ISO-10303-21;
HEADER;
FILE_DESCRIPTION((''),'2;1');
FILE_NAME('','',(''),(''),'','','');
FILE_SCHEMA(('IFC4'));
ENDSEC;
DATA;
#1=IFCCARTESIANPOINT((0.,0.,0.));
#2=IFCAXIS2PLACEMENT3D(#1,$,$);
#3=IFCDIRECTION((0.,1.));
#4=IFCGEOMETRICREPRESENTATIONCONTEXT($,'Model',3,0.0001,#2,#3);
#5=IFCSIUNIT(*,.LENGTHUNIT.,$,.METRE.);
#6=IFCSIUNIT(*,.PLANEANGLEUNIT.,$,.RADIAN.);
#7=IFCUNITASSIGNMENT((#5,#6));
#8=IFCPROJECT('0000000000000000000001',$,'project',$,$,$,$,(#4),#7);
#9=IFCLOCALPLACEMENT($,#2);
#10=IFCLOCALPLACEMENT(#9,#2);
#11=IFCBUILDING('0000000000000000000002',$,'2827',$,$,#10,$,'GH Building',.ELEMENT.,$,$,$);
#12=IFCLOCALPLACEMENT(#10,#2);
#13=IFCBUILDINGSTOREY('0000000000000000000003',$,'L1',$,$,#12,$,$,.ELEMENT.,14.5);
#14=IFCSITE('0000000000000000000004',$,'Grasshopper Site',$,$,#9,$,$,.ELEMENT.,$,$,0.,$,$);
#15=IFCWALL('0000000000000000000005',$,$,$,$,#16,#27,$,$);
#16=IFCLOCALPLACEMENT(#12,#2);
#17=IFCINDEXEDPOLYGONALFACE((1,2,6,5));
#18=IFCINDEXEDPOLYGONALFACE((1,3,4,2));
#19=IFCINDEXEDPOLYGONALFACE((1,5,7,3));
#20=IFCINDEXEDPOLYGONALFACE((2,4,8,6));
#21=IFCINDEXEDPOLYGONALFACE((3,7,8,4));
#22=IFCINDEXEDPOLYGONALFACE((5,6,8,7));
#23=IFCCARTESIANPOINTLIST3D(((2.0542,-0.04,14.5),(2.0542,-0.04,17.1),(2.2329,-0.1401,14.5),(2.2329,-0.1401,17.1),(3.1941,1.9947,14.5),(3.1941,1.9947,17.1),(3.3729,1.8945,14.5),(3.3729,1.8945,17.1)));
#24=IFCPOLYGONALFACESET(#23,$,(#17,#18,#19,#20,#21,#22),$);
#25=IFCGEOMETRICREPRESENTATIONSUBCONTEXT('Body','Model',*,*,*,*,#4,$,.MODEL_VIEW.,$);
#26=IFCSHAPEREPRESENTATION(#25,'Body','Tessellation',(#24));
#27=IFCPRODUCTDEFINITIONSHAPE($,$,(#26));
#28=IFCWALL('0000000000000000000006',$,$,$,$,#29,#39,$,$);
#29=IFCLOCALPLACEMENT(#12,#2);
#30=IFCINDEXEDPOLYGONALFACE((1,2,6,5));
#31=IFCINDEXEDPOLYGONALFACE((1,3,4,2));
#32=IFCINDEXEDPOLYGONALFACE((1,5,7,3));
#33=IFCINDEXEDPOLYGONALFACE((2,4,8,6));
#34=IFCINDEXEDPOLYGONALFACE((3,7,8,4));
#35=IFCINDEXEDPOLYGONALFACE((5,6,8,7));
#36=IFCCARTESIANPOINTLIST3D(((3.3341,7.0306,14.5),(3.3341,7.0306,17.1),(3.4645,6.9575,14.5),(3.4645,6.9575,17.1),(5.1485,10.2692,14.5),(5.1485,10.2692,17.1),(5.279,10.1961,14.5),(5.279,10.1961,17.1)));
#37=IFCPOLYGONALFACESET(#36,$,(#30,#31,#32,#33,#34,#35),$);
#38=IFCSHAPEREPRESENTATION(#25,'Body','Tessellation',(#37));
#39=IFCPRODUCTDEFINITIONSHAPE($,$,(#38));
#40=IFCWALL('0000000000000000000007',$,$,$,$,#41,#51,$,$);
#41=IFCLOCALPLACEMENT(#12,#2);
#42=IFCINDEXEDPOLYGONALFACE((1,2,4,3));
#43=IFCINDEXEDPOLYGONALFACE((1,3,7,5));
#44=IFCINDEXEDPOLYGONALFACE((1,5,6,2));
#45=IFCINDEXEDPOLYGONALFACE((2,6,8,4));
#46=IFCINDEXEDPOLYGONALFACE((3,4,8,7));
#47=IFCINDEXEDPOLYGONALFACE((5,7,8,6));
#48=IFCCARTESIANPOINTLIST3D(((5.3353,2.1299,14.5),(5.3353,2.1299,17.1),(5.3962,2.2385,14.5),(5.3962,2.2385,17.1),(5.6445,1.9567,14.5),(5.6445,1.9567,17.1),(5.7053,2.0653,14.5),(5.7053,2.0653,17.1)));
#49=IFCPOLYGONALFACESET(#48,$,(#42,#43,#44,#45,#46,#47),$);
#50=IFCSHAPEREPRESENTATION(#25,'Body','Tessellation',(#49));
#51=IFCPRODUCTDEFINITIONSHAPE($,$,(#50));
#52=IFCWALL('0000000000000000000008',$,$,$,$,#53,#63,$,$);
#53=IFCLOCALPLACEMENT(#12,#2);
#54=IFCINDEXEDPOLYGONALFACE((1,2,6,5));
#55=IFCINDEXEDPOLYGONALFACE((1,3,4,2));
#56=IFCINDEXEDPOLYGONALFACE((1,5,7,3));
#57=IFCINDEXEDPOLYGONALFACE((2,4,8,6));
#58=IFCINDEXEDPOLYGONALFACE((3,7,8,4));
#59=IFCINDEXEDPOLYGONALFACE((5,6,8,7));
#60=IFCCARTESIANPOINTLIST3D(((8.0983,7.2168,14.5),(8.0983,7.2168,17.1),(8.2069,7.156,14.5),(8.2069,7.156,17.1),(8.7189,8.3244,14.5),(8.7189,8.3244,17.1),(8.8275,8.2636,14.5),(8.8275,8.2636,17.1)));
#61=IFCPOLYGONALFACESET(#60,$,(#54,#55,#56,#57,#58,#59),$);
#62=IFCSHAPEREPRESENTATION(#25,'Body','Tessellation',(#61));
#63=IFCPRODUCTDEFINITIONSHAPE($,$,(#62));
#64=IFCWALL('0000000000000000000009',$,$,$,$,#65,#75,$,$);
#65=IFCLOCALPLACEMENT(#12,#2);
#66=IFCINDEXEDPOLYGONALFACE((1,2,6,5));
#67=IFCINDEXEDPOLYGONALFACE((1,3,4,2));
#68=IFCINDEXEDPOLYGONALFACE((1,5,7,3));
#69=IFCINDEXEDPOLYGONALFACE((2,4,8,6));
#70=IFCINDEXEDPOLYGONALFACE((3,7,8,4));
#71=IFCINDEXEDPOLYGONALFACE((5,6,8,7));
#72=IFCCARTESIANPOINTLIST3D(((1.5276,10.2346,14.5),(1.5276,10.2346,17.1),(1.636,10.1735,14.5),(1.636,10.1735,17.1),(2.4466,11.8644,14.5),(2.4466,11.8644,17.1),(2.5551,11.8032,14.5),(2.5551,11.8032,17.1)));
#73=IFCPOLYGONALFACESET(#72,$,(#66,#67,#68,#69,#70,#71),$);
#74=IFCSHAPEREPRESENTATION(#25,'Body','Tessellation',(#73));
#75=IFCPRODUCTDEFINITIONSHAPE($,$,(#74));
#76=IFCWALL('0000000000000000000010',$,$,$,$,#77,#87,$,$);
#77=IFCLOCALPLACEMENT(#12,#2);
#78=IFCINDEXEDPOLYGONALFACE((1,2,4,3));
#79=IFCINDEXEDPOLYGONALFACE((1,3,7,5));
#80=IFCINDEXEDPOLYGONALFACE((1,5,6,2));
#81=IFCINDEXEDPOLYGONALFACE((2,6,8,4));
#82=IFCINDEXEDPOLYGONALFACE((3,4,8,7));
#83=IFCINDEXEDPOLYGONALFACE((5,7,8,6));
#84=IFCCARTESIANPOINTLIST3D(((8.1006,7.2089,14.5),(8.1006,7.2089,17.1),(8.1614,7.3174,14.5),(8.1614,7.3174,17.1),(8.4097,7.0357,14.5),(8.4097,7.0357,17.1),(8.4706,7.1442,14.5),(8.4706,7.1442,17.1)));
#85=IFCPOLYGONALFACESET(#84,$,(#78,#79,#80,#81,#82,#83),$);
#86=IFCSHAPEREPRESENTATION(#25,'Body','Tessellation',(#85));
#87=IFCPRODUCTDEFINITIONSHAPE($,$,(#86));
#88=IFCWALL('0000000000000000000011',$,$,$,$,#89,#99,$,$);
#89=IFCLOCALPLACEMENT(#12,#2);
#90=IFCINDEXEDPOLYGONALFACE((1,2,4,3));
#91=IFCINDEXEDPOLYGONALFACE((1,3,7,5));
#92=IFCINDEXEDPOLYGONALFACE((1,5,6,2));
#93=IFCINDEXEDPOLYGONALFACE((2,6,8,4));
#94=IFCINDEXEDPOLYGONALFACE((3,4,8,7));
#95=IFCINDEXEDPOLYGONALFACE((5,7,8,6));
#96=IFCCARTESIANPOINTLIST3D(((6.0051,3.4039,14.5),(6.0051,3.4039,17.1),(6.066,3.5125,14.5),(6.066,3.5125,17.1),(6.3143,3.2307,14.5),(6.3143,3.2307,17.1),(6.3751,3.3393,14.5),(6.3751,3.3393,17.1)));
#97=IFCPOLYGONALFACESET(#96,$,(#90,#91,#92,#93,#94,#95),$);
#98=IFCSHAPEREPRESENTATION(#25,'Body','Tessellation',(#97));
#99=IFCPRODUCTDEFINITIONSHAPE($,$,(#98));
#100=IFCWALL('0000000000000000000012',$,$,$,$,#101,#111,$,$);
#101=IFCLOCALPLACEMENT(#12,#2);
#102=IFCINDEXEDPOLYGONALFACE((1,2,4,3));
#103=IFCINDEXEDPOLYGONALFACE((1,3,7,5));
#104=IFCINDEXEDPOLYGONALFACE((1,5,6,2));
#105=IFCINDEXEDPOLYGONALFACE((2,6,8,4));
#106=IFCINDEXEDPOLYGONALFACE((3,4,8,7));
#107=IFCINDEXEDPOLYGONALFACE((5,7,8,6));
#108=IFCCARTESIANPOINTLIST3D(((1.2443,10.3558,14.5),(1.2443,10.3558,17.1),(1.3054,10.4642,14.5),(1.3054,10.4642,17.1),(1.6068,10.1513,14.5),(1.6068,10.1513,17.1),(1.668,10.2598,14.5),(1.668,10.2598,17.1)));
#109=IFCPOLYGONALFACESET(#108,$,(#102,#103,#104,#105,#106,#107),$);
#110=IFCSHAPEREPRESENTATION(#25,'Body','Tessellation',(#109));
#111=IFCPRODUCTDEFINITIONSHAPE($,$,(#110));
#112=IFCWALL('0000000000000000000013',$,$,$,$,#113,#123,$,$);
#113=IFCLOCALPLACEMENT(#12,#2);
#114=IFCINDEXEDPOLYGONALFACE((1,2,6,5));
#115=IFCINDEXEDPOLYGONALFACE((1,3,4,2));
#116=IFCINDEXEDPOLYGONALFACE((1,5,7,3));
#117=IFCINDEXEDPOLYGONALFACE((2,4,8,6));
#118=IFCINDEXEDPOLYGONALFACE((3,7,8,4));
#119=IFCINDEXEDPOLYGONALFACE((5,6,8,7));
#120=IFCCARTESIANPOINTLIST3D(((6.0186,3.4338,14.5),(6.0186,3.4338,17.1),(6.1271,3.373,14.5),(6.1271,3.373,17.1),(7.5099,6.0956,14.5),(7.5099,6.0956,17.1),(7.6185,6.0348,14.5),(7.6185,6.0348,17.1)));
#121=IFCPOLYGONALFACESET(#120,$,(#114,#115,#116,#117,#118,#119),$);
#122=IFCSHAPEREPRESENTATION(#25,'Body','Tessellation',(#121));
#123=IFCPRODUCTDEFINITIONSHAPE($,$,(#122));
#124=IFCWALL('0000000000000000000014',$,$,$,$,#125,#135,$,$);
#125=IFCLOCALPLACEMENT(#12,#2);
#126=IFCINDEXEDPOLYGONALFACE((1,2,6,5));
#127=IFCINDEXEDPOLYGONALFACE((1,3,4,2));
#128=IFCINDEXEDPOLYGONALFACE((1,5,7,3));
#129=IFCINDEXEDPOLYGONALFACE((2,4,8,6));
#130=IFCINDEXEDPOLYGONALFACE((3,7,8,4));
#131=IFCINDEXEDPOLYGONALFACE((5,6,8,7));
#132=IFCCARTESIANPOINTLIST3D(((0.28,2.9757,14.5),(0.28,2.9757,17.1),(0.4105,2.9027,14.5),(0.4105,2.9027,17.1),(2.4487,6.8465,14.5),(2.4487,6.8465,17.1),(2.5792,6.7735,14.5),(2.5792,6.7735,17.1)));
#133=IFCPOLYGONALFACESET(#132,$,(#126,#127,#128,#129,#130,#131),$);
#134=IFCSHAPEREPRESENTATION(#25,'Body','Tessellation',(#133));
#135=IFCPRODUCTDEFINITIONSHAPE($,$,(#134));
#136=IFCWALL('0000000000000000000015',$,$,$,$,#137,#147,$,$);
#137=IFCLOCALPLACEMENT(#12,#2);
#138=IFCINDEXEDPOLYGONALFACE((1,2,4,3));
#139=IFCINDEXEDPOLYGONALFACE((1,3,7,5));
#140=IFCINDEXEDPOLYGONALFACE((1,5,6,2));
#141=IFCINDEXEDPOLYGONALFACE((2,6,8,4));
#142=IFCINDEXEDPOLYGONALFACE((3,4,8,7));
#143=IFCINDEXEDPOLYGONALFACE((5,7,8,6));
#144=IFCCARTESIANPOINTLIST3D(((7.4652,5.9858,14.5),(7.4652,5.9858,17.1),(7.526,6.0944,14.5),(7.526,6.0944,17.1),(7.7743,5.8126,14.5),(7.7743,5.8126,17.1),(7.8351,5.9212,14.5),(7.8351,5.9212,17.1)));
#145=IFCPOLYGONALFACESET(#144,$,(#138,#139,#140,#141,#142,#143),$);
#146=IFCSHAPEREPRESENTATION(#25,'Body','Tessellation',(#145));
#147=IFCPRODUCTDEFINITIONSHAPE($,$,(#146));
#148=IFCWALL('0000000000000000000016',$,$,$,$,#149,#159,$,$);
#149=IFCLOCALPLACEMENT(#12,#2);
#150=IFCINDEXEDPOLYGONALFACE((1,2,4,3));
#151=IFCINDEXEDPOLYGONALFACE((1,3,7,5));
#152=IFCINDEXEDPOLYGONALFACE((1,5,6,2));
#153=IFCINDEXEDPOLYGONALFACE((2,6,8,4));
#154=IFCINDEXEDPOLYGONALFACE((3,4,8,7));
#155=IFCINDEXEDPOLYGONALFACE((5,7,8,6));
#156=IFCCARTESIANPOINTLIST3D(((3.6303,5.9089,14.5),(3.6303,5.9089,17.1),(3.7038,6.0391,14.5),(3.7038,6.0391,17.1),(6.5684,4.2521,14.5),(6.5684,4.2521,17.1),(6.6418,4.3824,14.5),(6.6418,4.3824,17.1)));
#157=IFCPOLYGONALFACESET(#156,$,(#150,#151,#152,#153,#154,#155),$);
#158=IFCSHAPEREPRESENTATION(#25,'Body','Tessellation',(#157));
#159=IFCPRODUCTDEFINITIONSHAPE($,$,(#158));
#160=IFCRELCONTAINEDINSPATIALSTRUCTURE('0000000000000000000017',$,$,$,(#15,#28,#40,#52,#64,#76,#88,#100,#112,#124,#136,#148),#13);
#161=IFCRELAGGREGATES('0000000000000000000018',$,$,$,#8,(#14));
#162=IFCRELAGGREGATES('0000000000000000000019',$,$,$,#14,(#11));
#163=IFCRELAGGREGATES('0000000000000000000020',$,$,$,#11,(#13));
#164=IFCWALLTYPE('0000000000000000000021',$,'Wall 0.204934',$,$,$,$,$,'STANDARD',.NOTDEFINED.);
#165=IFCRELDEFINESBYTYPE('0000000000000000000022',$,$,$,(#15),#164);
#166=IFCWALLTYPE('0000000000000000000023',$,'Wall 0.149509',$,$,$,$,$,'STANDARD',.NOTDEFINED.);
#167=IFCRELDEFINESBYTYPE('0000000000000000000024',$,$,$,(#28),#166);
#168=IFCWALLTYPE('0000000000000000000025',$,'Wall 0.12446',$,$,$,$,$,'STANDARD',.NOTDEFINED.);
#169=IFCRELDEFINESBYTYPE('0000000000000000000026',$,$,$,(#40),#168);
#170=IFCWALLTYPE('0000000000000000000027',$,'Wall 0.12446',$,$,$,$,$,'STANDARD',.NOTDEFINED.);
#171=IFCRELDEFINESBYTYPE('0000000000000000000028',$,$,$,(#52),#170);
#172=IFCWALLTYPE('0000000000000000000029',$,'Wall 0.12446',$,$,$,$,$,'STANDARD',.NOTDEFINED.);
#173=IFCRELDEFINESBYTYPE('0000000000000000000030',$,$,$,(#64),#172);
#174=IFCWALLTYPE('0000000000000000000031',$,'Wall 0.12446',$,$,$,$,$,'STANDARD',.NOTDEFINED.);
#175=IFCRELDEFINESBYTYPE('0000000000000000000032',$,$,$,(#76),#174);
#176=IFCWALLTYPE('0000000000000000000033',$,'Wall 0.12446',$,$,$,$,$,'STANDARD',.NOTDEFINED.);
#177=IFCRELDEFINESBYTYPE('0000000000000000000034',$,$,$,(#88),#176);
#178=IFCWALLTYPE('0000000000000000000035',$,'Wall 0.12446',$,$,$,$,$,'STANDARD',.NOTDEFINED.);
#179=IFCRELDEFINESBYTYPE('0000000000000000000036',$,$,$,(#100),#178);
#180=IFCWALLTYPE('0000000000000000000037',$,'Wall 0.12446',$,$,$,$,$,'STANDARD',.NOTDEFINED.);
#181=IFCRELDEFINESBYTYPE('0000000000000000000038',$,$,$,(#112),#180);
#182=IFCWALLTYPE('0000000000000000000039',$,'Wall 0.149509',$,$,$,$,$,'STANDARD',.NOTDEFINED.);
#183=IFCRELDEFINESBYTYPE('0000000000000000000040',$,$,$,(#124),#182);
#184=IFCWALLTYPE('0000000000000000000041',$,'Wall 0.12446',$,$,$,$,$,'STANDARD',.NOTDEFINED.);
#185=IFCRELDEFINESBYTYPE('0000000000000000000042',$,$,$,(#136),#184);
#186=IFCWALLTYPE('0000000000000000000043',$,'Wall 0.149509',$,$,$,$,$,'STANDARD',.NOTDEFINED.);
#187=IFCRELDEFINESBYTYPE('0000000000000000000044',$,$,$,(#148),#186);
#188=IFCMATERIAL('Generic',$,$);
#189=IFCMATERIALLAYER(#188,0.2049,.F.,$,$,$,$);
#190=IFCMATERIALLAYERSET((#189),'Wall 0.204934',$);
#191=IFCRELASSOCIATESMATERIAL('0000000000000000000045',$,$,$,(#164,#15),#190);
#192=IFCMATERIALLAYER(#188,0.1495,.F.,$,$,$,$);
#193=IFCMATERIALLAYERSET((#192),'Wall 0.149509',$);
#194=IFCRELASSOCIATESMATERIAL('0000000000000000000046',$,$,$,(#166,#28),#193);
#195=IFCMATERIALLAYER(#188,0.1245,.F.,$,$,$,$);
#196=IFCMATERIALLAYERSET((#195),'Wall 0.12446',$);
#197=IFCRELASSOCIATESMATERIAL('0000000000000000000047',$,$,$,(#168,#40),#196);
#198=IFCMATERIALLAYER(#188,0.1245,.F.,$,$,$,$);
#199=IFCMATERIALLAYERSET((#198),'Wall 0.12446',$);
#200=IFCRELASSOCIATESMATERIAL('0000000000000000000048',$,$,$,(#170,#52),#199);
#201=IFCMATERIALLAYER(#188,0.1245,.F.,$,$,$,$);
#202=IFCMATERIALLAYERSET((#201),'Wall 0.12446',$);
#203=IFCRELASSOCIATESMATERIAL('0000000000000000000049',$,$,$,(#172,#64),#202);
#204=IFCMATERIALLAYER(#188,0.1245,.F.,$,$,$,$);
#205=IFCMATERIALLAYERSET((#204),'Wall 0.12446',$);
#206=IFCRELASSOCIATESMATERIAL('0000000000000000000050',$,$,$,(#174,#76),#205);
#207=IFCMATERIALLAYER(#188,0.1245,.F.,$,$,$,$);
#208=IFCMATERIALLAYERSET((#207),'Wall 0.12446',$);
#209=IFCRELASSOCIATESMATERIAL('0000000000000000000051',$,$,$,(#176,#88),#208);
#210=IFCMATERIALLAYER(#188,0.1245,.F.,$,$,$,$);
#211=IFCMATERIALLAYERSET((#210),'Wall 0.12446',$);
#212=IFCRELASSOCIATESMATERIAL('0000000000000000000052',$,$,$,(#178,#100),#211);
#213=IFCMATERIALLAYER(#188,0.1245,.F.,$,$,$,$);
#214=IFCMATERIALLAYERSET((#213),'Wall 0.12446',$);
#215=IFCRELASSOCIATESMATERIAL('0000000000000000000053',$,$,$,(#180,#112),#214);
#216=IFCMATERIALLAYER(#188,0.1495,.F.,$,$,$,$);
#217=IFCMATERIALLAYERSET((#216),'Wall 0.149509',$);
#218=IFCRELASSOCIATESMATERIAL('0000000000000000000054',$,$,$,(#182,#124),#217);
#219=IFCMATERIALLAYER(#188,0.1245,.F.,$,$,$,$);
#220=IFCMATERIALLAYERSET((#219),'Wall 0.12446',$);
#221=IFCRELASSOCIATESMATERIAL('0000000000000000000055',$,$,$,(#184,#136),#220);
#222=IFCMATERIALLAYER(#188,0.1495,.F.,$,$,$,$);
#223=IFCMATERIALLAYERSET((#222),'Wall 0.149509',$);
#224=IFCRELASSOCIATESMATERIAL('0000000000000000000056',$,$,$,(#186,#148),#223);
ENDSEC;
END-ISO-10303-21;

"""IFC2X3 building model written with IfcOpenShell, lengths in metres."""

from ifc_helpers import new_model, si_unit, direction, frame, frame_2d, origin, place, context, subcontext, project, spatial, rectangle, extrude, material, layer, layer_set, layer_usage, type_object, element, save


model = new_model("IFC2X3")

# Units and contexts
model_context = context("Model", 3, precision=0.0001, world=origin(), true_north=direction((0.0, 1.0)))
body_context = subcontext(model_context, "Body", "Model", "MODEL_VIEW")
ifc_project = project(units=[si_unit("LENGTHUNIT", "METRE"), si_unit("PLANEANGLEUNIT", "RADIAN")], contexts=[model_context])

# Site, building, storey
site_placement = place(None, origin())
site = spatial("IfcSite", under=ifc_project, at=site_placement, Name="Grasshopper Site", CompositionType="ELEMENT", RefElevation=0.0)
building_placement = place(site_placement, origin())
building = spatial("IfcBuilding", under=site, at=building_placement, Name="2827", LongName="GH Building", CompositionType="ELEMENT")
storey_placement = place(building_placement, origin())
storey = spatial("IfcBuildingStorey", under=building, at=storey_placement, Name="L1", CompositionType="ELEMENT", Elevation=14.5)

# Walls
ifc_material = material(Name="Generic")
ifc_layer_1 = layer(ifc_material, 0.2049, ventilated=False)
ifc_layer_set_1 = layer_set([ifc_layer_1], Name="Wall 0.204934")
ifc_layer_usage_1 = layer_usage(ifc_layer_set_1, "AXIS2", "NEGATIVE", 0.1025)
wall_type_1 = type_object("IfcWallType", Name="Wall 0.204934", ElementType="STANDARD", PredefinedType="NOTDEFINED", material=ifc_layer_set_1)
wall_1_placement = place(storey_placement, frame((3.2835, 1.9446, 14.5), z_axis=(0.0, 0.0, 1.0), x_axis=(-0.488782, -0.872406, 0.0)))
element("IfcWall", 1, at=wall_1_placement, inside=storey, type_object=wall_type_1, material=ifc_layer_usage_1, context=body_context, shape_type="SweptSolid", body=[
    extrude(rectangle(XDim=2.3322, YDim=0.2049, at=frame_2d((1.1661, 0.0))), origin(), (0.0, 0.0, 1.0), 2.6),
])
ifc_layer_2 = layer(ifc_material, 0.1495, ventilated=False)
ifc_layer_set_2 = layer_set([ifc_layer_2], Name="Wall 0.149509")
ifc_layer_usage_2 = layer_usage(ifc_layer_set_2, "AXIS2", "NEGATIVE", 0.0748)
wall_type_2 = type_object("IfcWallType", Name="Wall 0.149509", ElementType="STANDARD", PredefinedType="NOTDEFINED", material=ifc_layer_set_2)
wall_2_placement = place(storey_placement, frame((5.2138, 10.2327, 14.5), z_axis=(0.0, 0.0, 1.0), x_axis=(-0.488782, -0.872406, 0.0)))
element("IfcWall", 2, at=wall_2_placement, inside=storey, type_object=wall_type_2, material=ifc_layer_usage_2, context=body_context, shape_type="SweptSolid", body=[
    extrude(rectangle(XDim=3.7122, YDim=0.1495, at=frame_2d((1.8561, 0.0))), origin(), (0.0, 0.0, 1.0), 2.6),
])

# Walls
ifc_layer_3 = layer(ifc_material, 0.1245, ventilated=False)
ifc_layer_set_3 = layer_set([ifc_layer_3], Name="Wall 0.12446")
ifc_layer_usage_3 = layer_usage(ifc_layer_set_3, "AXIS2", "NEGATIVE", 0.0622)
wall_type_3 = type_object("IfcWallType", Name="Wall 0.12446", ElementType="STANDARD", PredefinedType="NOTDEFINED", material=ifc_layer_set_3)
wall_3_placement = place(storey_placement, frame((5.3657, 2.1842, 14.5), z_axis=(0.0, 0.0, 1.0), x_axis=(0.872406, -0.488782, 0.0)))
element("IfcWall", 3, at=wall_3_placement, inside=storey, type_object=wall_type_3, material=ifc_layer_usage_3, context=body_context, shape_type="SweptSolid", body=[
    extrude(rectangle(XDim=0.3544, YDim=0.1245, at=frame_2d((0.1772, 0.0))), origin(), (0.0, 0.0, 1.0), 2.6),
])
ifc_layer_4 = layer(ifc_material, 0.1245, ventilated=False)
ifc_layer_set_4 = layer_set([ifc_layer_4], Name="Wall 0.12446")
ifc_layer_usage_4 = layer_usage(ifc_layer_set_4, "AXIS2", "NEGATIVE", 0.0622)
wall_type_4 = type_object("IfcWallType", Name="Wall 0.12446", ElementType="STANDARD", PredefinedType="NOTDEFINED", material=ifc_layer_set_4)
wall_4_placement = place(storey_placement, frame((8.7732, 8.294, 14.5), z_axis=(0.0, 0.0, 1.0), x_axis=(-0.488782, -0.872406, 0.0)))
element("IfcWall", 4, at=wall_4_placement, inside=storey, type_object=wall_type_4, material=ifc_layer_usage_4, context=body_context, shape_type="SweptSolid", body=[
    extrude(rectangle(XDim=1.2696, YDim=0.1245, at=frame_2d((0.6348, 0.0))), origin(), (0.0, 0.0, 1.0), 2.6),
])
ifc_layer_5 = layer(ifc_material, 0.1245, ventilated=False)
ifc_layer_set_5 = layer_set([ifc_layer_5], Name="Wall 0.12446")
ifc_layer_usage_5 = layer_usage(ifc_layer_set_5, "AXIS2", "NEGATIVE", 0.0622)
wall_type_5 = type_object("IfcWallType", Name="Wall 0.12446", ElementType="STANDARD", PredefinedType="NOTDEFINED", material=ifc_layer_set_5)
wall_5_placement = place(storey_placement, frame((1.5818, 10.204, 14.5), z_axis=(0.0, 0.0, 1.0), x_axis=(0.491187, 0.871054, 0.0)))
element("IfcWall", 5, at=wall_5_placement, inside=storey, type_object=wall_type_5, material=ifc_layer_usage_5, context=body_context, shape_type="SweptSolid", body=[
    extrude(rectangle(XDim=1.871, YDim=0.1245, at=frame_2d((0.9355, 0.0))), origin(), (0.0, 0.0, 1.0), 2.6),
])
ifc_layer_6 = layer(ifc_material, 0.1245, ventilated=False)
ifc_layer_set_6 = layer_set([ifc_layer_6], Name="Wall 0.12446")
ifc_layer_usage_6 = layer_usage(ifc_layer_set_6, "AXIS2", "NEGATIVE", 0.0622)
wall_type_6 = type_object("IfcWallType", Name="Wall 0.12446", ElementType="STANDARD", PredefinedType="NOTDEFINED", material=ifc_layer_set_6)
wall_6_placement = place(storey_placement, frame((8.4402, 7.0899, 14.5), z_axis=(0.0, 0.0, 1.0), x_axis=(-0.872406, 0.488782, 0.0)))
element("IfcWall", 6, at=wall_6_placement, inside=storey, type_object=wall_type_6, material=ifc_layer_usage_6, context=body_context, shape_type="SweptSolid", body=[
    extrude(rectangle(XDim=0.3544, YDim=0.1245, at=frame_2d((0.1772, 0.0))), origin(), (0.0, 0.0, 1.0), 2.6),
])
ifc_layer_7 = layer(ifc_material, 0.1245, ventilated=False)
ifc_layer_set_7 = layer_set([ifc_layer_7], Name="Wall 0.12446")
ifc_layer_usage_7 = layer_usage(ifc_layer_set_7, "AXIS2", "NEGATIVE", 0.0622)
wall_type_7 = type_object("IfcWallType", Name="Wall 0.12446", ElementType="STANDARD", PredefinedType="NOTDEFINED", material=ifc_layer_set_7)
wall_7_placement = place(storey_placement, frame((6.0355, 3.4582, 14.5), z_axis=(0.0, 0.0, 1.0), x_axis=(0.872406, -0.488782, 0.0)))
element("IfcWall", 7, at=wall_7_placement, inside=storey, type_object=wall_type_7, material=ifc_layer_usage_7, context=body_context, shape_type="SweptSolid", body=[
    extrude(rectangle(XDim=0.3544, YDim=0.1245, at=frame_2d((0.1772, 0.0))), origin(), (0.0, 0.0, 1.0), 2.6),
])
ifc_layer_8 = layer(ifc_material, 0.1245, ventilated=False)
ifc_layer_set_8 = layer_set([ifc_layer_8], Name="Wall 0.12446")
ifc_layer_usage_8 = layer_usage(ifc_layer_set_8, "AXIS2", "NEGATIVE", 0.0622)
wall_type_8 = type_object("IfcWallType", Name="Wall 0.12446", ElementType="STANDARD", PredefinedType="NOTDEFINED", material=ifc_layer_set_8)
wall_8_placement = place(storey_placement, frame((1.6374, 10.2056, 14.5), z_axis=(0.0, 0.0, 1.0), x_axis=(-0.871054, 0.491187, 0.0)))
element("IfcWall", 8, at=wall_8_placement, inside=storey, type_object=wall_type_8, material=ifc_layer_usage_8, context=body_context, shape_type="SweptSolid", body=[
    extrude(rectangle(XDim=0.4162, YDim=0.1245, at=frame_2d((0.2081, 0.0))), origin(), (0.0, 0.0, 1.0), 2.6),
])

# Walls
ifc_layer_9 = layer(ifc_material, 0.1245, ventilated=False)
ifc_layer_set_9 = layer_set([ifc_layer_9], Name="Wall 0.12446")
ifc_layer_usage_9 = layer_usage(ifc_layer_set_9, "AXIS2", "NEGATIVE", 0.0622)
wall_type_9 = type_object("IfcWallType", Name="Wall 0.12446", ElementType="STANDARD", PredefinedType="NOTDEFINED", material=ifc_layer_set_9)
wall_9_placement = place(storey_placement, frame((7.5642, 6.0652, 14.5), z_axis=(0.0, 0.0, 1.0), x_axis=(-0.488782, -0.872406, 0.0)))
element("IfcWall", 9, at=wall_9_placement, inside=storey, type_object=wall_type_9, material=ifc_layer_usage_9, context=body_context, shape_type="SweptSolid", body=[
    extrude(rectangle(XDim=3.0511, YDim=0.1245, at=frame_2d((1.5256, 0.0))), origin(), (0.0, 0.0, 1.0), 2.6),
])
ifc_layer_10 = layer(ifc_material, 0.1495, ventilated=False)
ifc_layer_set_10 = layer_set([ifc_layer_10], Name="Wall 0.149509")
ifc_layer_usage_10 = layer_usage(ifc_layer_set_10, "AXIS2", "NEGATIVE", 0.0748)
wall_type_10 = type_object("IfcWallType", Name="Wall 0.149509", ElementType="STANDARD", PredefinedType="NOTDEFINED", material=ifc_layer_set_10)
wall_10_placement = place(storey_placement, frame((2.5139, 6.81, 14.5), z_axis=(0.0, 0.0, 1.0), x_axis=(-0.488782, -0.872406, 0.0)))
element("IfcWall", 10, at=wall_10_placement, inside=storey, type_object=wall_type_10, material=ifc_layer_usage_10, context=body_context, shape_type="SweptSolid", body=[
    extrude(rectangle(XDim=4.4369, YDim=0.1495, at=frame_2d((2.2185, 0.0))), origin(), (0.0, 0.0, 1.0), 2.6),
])

# Walls
ifc_layer_11 = layer(ifc_material, 0.1245, ventilated=False)
ifc_layer_set_11 = layer_set([ifc_layer_11], Name="Wall 0.12446")
ifc_layer_usage_11 = layer_usage(ifc_layer_set_11, "AXIS2", "NEGATIVE", 0.0622)
wall_type_11 = type_object("IfcWallType", Name="Wall 0.12446", ElementType="STANDARD", PredefinedType="NOTDEFINED", material=ifc_layer_set_11)
wall_11_placement = place(storey_placement, frame((7.4956, 6.0401, 14.5), z_axis=(0.0, 0.0, 1.0), x_axis=(0.872406, -0.488782, 0.0)))
element("IfcWall", 11, at=wall_11_placement, inside=storey, type_object=wall_type_11, material=ifc_layer_usage_11, context=body_context, shape_type="SweptSolid", body=[
    extrude(rectangle(XDim=0.3544, YDim=0.1245, at=frame_2d((0.1772, 0.0))), origin(), (0.0, 0.0, 1.0), 2.6),
])
ifc_layer_12 = layer(ifc_material, 0.1495, ventilated=False)
ifc_layer_set_12 = layer_set([ifc_layer_12], Name="Wall 0.149509")
ifc_layer_usage_12 = layer_usage(ifc_layer_set_12, "AXIS2", "NEGATIVE", 0.0748)
wall_type_12 = type_object("IfcWallType", Name="Wall 0.149509", ElementType="STANDARD", PredefinedType="NOTDEFINED", material=ifc_layer_set_12)
wall_12_placement = place(storey_placement, frame((3.6671, 5.974, 14.5), z_axis=(0.0, 0.0, 1.0), x_axis=(0.871054, -0.491187, 0.0)))
element("IfcWall", 12, at=wall_12_placement, inside=storey, type_object=wall_type_12, material=ifc_layer_usage_12, context=body_context, shape_type="SweptSolid", body=[
    extrude(rectangle(XDim=3.373, YDim=0.1495, at=frame_2d((1.6865, 0.0))), origin(), (0.0, 0.0, 1.0), 2.6),
])

save(model, "model.ifc")
